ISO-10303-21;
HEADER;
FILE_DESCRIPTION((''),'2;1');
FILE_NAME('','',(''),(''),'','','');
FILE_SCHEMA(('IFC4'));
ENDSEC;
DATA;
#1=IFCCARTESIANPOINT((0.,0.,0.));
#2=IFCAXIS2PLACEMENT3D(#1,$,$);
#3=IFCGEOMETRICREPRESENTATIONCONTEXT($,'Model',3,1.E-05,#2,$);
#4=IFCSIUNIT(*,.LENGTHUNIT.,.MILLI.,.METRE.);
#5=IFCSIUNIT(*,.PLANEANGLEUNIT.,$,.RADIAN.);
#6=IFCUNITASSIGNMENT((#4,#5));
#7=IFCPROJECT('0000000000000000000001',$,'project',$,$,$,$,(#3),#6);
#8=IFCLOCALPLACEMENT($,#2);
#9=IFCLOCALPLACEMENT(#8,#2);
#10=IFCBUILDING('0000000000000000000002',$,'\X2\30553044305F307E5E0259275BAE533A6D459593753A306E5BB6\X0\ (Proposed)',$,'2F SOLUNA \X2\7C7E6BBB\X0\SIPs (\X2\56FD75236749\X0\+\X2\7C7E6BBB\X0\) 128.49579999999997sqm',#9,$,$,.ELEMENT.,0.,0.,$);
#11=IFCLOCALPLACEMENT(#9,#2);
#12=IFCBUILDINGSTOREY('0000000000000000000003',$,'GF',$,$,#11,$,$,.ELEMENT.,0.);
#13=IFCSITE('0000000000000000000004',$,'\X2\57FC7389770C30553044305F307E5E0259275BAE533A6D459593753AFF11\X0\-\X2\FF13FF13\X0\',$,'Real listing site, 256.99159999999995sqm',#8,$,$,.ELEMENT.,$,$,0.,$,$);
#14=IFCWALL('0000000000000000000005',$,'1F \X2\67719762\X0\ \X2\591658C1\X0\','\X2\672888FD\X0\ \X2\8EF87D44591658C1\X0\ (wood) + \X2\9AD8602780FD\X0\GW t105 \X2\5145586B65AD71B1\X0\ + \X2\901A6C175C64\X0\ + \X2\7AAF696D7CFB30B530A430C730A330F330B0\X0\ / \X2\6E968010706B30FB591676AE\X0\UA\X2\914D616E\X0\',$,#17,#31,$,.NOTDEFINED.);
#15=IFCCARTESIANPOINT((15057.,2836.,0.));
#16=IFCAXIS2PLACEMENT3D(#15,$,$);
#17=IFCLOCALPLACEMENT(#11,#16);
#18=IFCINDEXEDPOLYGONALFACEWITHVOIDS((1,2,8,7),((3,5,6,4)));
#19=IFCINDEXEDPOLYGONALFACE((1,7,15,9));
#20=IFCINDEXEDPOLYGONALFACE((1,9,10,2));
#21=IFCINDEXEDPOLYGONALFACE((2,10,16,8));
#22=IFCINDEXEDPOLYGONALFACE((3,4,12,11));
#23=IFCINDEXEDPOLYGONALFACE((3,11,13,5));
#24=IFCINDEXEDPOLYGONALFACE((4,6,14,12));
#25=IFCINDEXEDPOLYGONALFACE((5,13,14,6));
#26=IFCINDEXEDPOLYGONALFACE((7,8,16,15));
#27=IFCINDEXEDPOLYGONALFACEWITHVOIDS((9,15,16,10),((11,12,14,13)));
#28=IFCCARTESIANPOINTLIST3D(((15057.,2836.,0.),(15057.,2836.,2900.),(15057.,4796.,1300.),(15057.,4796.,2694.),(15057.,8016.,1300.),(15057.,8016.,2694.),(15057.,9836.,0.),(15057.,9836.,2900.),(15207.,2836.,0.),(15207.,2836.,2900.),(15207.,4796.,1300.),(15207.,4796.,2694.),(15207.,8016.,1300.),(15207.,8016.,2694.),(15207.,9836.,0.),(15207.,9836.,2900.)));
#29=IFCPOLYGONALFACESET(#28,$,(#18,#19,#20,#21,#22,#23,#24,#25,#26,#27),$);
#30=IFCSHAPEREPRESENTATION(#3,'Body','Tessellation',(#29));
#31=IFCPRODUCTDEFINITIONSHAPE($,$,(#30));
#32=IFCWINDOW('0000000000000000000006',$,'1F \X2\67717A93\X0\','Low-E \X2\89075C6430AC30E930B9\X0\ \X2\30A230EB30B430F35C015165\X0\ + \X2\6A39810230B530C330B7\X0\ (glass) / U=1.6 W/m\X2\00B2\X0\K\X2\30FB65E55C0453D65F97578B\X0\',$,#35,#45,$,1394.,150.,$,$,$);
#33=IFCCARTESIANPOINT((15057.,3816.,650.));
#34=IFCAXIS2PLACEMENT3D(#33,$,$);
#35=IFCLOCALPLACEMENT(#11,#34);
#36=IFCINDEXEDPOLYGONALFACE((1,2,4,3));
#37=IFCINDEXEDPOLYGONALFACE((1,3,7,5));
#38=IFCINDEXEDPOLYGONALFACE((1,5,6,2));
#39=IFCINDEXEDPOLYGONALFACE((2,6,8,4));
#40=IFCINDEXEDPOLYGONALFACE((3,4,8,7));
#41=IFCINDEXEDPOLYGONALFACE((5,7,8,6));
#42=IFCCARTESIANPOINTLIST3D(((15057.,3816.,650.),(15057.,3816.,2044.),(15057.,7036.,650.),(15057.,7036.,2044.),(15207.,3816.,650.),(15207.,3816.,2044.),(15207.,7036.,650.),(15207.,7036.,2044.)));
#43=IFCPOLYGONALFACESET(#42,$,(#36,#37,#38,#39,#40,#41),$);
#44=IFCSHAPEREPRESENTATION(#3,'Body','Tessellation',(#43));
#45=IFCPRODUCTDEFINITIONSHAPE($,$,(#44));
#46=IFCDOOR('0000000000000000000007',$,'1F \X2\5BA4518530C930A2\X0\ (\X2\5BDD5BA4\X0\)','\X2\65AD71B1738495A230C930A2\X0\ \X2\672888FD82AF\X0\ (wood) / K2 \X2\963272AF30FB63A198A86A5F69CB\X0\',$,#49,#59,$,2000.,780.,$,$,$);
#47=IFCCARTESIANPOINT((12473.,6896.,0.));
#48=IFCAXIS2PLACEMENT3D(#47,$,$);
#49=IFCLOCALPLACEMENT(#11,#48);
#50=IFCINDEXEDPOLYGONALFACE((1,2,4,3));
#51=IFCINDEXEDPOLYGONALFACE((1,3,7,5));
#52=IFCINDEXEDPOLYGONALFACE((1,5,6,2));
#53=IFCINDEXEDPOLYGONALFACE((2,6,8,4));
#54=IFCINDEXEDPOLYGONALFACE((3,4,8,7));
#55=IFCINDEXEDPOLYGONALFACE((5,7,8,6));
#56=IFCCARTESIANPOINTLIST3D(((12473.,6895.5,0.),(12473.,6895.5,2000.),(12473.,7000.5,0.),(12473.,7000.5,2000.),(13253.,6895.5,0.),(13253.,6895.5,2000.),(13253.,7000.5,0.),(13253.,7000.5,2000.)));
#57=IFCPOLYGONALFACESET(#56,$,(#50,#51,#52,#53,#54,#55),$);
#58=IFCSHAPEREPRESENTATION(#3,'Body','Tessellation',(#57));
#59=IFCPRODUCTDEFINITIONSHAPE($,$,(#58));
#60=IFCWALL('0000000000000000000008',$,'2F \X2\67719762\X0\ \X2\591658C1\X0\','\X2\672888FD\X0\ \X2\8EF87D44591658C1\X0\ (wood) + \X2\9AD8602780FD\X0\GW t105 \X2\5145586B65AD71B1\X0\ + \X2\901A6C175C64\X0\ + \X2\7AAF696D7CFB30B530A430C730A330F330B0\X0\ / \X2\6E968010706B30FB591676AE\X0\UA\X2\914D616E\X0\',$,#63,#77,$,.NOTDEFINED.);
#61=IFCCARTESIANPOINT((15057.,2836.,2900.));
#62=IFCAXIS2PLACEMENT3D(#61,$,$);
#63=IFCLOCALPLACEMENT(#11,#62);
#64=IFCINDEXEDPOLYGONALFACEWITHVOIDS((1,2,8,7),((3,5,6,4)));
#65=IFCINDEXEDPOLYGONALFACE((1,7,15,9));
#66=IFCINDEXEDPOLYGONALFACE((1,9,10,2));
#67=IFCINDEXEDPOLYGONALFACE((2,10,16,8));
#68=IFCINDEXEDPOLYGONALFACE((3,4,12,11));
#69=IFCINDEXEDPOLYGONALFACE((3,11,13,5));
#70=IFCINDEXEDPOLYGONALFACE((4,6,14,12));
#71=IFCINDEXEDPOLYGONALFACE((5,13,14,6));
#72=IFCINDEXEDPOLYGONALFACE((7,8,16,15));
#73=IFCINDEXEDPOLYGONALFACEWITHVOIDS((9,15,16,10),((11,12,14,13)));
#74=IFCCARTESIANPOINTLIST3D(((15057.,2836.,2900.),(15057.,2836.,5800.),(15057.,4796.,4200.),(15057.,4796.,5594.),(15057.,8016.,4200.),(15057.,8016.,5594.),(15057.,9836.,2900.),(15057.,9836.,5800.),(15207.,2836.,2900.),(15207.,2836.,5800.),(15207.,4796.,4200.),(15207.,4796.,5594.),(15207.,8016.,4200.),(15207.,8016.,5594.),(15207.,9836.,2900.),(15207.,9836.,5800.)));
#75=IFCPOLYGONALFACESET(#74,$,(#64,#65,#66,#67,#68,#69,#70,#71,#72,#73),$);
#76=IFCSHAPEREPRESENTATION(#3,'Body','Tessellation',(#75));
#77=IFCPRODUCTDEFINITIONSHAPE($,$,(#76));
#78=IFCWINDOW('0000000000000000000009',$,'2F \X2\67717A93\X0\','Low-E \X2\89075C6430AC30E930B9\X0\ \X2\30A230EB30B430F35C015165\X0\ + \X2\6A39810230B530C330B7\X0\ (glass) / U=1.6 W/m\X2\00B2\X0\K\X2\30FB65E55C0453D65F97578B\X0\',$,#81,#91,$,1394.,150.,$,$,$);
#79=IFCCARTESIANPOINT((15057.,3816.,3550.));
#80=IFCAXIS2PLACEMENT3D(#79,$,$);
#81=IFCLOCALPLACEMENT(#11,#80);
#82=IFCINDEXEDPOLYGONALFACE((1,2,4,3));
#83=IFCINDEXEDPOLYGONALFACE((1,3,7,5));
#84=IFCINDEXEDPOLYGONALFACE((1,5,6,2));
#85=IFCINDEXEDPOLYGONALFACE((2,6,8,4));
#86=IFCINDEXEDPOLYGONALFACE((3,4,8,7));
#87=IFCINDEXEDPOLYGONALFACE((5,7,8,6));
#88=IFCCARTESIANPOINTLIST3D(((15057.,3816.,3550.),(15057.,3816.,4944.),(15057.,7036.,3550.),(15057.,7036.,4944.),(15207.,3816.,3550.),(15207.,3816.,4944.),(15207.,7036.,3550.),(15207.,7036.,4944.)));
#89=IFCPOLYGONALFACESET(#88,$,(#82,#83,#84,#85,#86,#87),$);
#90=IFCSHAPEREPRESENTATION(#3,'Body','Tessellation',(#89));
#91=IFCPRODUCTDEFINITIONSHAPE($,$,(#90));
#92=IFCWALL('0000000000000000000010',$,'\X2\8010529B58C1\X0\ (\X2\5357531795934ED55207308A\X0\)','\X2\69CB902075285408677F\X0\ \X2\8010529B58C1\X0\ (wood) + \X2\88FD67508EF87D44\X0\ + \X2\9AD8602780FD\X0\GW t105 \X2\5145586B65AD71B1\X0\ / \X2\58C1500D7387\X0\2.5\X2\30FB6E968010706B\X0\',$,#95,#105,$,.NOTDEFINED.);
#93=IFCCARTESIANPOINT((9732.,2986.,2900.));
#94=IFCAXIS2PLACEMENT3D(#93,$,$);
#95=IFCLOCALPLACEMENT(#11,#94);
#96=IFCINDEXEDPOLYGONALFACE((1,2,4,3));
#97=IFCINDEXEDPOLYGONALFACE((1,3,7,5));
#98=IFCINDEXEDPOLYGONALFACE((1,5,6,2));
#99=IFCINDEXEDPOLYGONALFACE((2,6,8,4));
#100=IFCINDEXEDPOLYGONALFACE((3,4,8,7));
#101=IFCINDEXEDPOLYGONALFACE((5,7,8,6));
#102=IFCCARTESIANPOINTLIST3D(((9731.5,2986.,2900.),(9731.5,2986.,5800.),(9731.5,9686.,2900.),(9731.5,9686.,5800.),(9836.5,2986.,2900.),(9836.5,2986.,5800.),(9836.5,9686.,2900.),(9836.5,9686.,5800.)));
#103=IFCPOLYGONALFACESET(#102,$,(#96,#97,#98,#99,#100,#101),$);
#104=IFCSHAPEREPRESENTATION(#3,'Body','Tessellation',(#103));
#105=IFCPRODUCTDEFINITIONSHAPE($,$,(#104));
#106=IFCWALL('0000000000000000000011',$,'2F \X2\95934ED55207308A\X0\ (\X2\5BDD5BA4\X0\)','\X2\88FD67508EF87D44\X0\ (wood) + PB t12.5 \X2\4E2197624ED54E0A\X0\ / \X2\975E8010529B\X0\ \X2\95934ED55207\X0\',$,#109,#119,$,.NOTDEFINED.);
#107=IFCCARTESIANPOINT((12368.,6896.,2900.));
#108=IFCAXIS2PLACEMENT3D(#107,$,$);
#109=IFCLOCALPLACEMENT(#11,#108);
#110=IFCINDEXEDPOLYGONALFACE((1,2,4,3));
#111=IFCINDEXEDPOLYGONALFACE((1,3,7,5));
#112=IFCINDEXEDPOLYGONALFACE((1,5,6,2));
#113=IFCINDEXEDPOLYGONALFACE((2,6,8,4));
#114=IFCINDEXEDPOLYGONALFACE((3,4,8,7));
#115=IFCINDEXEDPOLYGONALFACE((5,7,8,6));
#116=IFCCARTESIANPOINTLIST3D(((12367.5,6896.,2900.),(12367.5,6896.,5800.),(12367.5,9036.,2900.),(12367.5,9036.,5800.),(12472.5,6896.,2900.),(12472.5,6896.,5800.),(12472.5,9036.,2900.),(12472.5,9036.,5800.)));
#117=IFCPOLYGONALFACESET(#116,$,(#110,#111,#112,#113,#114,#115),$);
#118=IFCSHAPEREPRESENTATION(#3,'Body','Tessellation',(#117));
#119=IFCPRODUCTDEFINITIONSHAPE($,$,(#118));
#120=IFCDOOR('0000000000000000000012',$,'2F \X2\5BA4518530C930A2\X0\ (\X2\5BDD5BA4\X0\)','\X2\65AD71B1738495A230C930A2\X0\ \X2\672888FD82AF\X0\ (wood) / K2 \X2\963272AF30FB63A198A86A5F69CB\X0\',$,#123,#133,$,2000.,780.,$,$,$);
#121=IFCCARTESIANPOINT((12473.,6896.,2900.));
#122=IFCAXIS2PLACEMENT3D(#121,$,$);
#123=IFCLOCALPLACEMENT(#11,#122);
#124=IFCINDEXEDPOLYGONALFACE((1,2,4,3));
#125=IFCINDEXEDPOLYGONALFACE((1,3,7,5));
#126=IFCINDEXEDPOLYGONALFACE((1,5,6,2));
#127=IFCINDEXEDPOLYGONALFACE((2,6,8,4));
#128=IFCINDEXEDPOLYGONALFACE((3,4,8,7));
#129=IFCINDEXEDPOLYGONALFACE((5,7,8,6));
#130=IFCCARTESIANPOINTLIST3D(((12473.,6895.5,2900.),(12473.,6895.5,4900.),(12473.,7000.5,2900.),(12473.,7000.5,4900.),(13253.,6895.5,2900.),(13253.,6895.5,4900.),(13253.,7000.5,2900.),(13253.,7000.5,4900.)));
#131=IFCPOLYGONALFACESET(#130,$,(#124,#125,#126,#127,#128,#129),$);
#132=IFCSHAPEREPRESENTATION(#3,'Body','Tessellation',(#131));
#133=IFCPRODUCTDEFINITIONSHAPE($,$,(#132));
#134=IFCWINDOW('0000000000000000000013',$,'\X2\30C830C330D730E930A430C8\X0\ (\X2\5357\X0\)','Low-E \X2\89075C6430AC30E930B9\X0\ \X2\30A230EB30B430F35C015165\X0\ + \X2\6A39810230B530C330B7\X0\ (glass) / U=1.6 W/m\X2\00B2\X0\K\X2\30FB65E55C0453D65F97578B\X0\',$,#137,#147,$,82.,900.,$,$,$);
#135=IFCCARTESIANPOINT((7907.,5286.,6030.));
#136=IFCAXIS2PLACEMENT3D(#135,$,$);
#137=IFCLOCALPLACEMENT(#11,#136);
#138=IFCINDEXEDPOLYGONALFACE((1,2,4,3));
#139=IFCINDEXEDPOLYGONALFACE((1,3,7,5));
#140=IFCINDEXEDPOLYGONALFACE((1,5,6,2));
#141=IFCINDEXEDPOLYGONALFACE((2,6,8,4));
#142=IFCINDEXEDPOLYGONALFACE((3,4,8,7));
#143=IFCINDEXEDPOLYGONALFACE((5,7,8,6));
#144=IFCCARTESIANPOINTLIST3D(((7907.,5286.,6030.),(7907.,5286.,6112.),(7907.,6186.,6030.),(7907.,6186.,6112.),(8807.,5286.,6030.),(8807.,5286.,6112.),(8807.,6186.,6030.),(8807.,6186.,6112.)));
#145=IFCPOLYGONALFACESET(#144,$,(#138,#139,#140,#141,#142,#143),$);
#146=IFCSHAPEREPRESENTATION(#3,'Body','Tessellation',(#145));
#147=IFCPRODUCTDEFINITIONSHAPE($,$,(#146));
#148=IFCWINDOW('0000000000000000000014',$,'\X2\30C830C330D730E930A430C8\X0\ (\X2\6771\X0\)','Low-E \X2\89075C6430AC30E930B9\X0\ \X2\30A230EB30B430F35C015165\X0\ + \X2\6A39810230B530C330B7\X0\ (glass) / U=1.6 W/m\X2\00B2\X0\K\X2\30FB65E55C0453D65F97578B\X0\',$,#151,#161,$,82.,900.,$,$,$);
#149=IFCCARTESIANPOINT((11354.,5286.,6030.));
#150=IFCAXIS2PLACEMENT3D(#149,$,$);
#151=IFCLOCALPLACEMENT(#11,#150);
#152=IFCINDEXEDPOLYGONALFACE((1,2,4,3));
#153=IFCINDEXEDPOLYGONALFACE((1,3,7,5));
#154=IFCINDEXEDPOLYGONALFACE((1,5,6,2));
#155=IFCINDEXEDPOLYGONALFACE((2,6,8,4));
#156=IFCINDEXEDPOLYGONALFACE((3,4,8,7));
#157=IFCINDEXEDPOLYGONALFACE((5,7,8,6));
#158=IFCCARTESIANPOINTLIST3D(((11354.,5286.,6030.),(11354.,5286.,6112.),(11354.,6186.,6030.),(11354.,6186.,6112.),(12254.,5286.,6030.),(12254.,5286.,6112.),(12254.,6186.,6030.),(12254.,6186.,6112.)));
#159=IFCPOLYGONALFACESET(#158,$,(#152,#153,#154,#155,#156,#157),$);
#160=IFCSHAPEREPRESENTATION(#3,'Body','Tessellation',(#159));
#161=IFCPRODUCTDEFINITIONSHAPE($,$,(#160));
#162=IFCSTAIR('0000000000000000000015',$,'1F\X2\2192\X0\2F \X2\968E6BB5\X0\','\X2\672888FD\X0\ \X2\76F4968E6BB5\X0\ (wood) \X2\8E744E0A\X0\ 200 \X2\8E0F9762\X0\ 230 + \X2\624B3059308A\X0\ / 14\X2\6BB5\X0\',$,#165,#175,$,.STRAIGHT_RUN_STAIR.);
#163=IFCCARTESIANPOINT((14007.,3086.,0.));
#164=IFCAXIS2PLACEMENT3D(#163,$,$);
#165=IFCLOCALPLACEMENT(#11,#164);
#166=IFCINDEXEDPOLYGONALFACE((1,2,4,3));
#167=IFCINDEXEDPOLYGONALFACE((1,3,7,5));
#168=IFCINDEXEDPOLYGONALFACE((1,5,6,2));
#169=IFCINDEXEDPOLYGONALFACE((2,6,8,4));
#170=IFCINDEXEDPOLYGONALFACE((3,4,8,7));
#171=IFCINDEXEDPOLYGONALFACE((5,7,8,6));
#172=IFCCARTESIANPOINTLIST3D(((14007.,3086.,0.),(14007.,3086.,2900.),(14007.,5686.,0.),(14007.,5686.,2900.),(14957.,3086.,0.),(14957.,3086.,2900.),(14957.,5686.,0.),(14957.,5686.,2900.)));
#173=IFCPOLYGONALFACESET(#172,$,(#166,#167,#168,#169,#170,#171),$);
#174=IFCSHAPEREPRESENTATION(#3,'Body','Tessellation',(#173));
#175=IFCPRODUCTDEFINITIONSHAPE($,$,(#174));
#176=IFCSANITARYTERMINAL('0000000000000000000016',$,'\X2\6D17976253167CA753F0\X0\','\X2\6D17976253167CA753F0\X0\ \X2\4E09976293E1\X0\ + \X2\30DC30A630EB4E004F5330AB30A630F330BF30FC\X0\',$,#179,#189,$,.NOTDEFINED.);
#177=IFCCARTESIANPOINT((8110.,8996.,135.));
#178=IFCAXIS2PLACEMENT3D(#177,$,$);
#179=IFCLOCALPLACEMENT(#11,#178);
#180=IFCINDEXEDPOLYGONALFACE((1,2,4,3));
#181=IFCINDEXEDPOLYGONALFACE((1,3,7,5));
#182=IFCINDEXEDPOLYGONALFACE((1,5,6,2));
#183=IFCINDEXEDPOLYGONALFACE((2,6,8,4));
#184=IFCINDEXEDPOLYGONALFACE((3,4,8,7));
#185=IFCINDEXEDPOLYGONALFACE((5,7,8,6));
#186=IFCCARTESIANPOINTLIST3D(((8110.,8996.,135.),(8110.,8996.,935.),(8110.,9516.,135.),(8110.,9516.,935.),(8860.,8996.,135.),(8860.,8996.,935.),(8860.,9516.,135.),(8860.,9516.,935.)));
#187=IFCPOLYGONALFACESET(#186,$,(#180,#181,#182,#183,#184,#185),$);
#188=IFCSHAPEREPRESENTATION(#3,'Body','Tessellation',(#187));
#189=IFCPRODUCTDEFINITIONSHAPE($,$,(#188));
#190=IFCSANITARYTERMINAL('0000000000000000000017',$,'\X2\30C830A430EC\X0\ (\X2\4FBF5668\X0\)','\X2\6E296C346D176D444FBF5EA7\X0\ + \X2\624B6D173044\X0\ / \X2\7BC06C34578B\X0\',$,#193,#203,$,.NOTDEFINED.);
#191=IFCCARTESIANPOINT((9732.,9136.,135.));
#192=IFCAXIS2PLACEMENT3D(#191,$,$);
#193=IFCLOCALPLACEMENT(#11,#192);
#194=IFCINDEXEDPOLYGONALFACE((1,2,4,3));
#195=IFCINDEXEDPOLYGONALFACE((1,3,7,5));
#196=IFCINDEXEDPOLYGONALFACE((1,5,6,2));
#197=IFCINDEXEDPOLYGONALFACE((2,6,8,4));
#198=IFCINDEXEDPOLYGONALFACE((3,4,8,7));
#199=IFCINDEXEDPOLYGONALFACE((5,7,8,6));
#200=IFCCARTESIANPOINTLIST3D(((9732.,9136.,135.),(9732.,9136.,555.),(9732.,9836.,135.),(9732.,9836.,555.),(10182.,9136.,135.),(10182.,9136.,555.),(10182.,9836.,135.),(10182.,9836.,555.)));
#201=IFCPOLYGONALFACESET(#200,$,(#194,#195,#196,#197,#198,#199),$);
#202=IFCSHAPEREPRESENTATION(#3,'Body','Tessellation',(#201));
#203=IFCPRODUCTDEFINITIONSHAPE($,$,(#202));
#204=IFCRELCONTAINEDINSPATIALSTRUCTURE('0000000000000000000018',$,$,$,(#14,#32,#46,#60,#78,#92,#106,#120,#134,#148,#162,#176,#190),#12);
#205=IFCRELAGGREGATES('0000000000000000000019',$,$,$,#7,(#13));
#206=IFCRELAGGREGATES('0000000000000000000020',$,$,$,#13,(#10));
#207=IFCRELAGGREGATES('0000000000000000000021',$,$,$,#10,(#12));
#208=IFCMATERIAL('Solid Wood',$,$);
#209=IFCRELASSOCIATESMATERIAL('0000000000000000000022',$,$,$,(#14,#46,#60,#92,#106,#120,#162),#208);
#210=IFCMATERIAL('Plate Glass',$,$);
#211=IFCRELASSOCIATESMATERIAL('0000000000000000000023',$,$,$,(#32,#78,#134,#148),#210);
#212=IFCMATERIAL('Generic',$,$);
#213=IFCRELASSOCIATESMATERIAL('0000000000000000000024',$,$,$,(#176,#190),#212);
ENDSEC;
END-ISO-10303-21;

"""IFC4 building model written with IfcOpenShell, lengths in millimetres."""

from ifc_helpers import new_model, si_unit, frame, frame_2d, origin, place, context, project, spatial, rectangle, extrude, material, element, fill, save


model = new_model("IFC4")

# Units and contexts
model_context = context("Model", 3, precision=1e-05, world=origin())
ifc_project = project(units=[si_unit("LENGTHUNIT", "METRE", prefix="MILLI"), si_unit("PLANEANGLEUNIT", "RADIAN")], contexts=[model_context])

# Site, building, storey
site_placement = place(None, origin())
site = spatial("IfcSite", under=ifc_project, at=site_placement, Name="埼玉県さいたま市大宮区浅間町１-３３", ObjectType="Real listing site, 256.99159999999995sqm", CompositionType="ELEMENT", RefElevation=0.0)
building_placement = place(site_placement, origin())
building = spatial("IfcBuilding", under=site, at=building_placement, Name="さいたま市大宮区浅間町の家 (Proposed)", ObjectType="2F SOLUNA 籾殻SIPs (国産杉+籾殻) 128.49579999999997sqm", CompositionType="ELEMENT", ElevationOfRefHeight=0.0, ElevationOfTerrain=0.0)
storey_placement = place(building_placement, origin())
storey = spatial("IfcBuildingStorey", under=building, at=storey_placement, Name="GF", CompositionType="ELEMENT", Elevation=0.0)

# Wall, opening, window
ifc_material_1 = material(Name="Solid Wood")
wall_1_placement = place(storey_placement, frame((15057.0, 2836.0, 0.0)))
wall_1 = element("IfcWall", 1, at=wall_1_placement, inside=storey, material=ifc_material_1, Name="1F 東面 外壁", Description="木製 軸組外壁 (wood) + 高性能GW t105 充填断熱 + 通気層 + 窯業系サイディング / 準耐火・外皮UA配慮", PredefinedType="NOTDEFINED", context=model_context, shape_type="SweptSolid", body=[
    extrude(rectangle(XDim=150.0, YDim=7000.0, at=frame_2d((75.0, 3500.0))), frame((15057.0, 2836.0, 0.0)), (0.0, 0.0, 1.0), 2900.0),
])
opening_1_placement = place(storey_placement, frame((15057.0, 3816.0, 650.0)))
opening_1 = element("IfcOpeningElement", 2, at=opening_1_placement, cuts=wall_1, PredefinedType="NOTDEFINED", context=model_context, shape_type="SweptSolid", body=[
    extrude(rectangle(XDim=150.0, YDim=3220.0, at=frame_2d((75.0, 1610.0))), frame((15057.0, 3816.0, 650.0)), (0.0, 0.0, 1.0), 1394.0),
])
ifc_material_2 = material(Name="Plate Glass")
window_1_placement = place(storey_placement, frame((15057.0, 3816.0, 650.0)))
window_1 = element("IfcWindow", 3, at=window_1_placement, inside=storey, material=ifc_material_2, Name="1F 東窓", Description="Low-E 複層ガラス アルゴン封入 + 樹脂サッシ (glass) / U=1.6 W/m²K・日射取得型", OverallHeight=1394.0, OverallWidth=150.0, context=model_context, shape_type="SweptSolid", body=[
    extrude(rectangle(XDim=150.0, YDim=3220.0, at=frame_2d((75.0, 1610.0))), frame((15057.0, 3816.0, 650.0)), (0.0, 0.0, 1.0), 1394.0),
])
fill(opening_1, window_1)

# Door
door_1_placement = place(storey_placement, frame((12473.0, 6896.0, 0.0)))
element("IfcDoor", 4, at=door_1_placement, inside=storey, material=ifc_material_1, Name="1F 室内ドア (寝室)", Description="断熱玄関ドア 木製芯 (wood) / K2 防犯・採風機構", OverallHeight=2000.0, OverallWidth=780.0, context=model_context, shape_type="SweptSolid", body=[
    extrude(rectangle(XDim=780.0, YDim=105.0, at=frame_2d((390.0, 52.0))), frame((12473.0, 6896.0, 0.0)), (0.0, 0.0, 1.0), 2000.0),
])

# Wall, opening, window
wall_2_placement = place(storey_placement, frame((15057.0, 2836.0, 2900.0)))
wall_2 = element("IfcWall", 5, at=wall_2_placement, inside=storey, material=ifc_material_1, Name="2F 東面 外壁", Description="木製 軸組外壁 (wood) + 高性能GW t105 充填断熱 + 通気層 + 窯業系サイディング / 準耐火・外皮UA配慮", PredefinedType="NOTDEFINED", context=model_context, shape_type="SweptSolid", body=[
    extrude(rectangle(XDim=150.0, YDim=7000.0, at=frame_2d((75.0, 3500.0))), frame((15057.0, 2836.0, 2900.0)), (0.0, 0.0, 1.0), 2900.0),
])
opening_2_placement = place(storey_placement, frame((15057.0, 3816.0, 3550.0)))
opening_2 = element("IfcOpeningElement", 6, at=opening_2_placement, cuts=wall_2, PredefinedType="NOTDEFINED", context=model_context, shape_type="SweptSolid", body=[
    extrude(rectangle(XDim=150.0, YDim=3220.0, at=frame_2d((75.0, 1610.0))), frame((15057.0, 3816.0, 3550.0)), (0.0, 0.0, 1.0), 1394.0),
])
window_2_placement = place(storey_placement, frame((15057.0, 3816.0, 3550.0)))
window_2 = element("IfcWindow", 7, at=window_2_placement, inside=storey, material=ifc_material_2, Name="2F 東窓", Description="Low-E 複層ガラス アルゴン封入 + 樹脂サッシ (glass) / U=1.6 W/m²K・日射取得型", OverallHeight=1394.0, OverallWidth=150.0, context=model_context, shape_type="SweptSolid", body=[
    extrude(rectangle(XDim=150.0, YDim=3220.0, at=frame_2d((75.0, 1610.0))), frame((15057.0, 3816.0, 3550.0)), (0.0, 0.0, 1.0), 1394.0),
])
fill(opening_2, window_2)

# Walls
wall_3_placement = place(storey_placement, frame((9732.0, 2986.0, 2900.0)))
element("IfcWall", 8, at=wall_3_placement, inside=storey, material=ifc_material_1, Name="耐力壁 (南北間仕切り)", Description="構造用合板 耐力壁 (wood) + 製材軸組 + 高性能GW t105 充填断熱 / 壁倍率2.5・準耐火", PredefinedType="NOTDEFINED", context=model_context, shape_type="SweptSolid", body=[
    extrude(rectangle(XDim=105.0, YDim=6700.0, at=frame_2d((52.0, 3350.0))), frame((9732.0, 2986.0, 2900.0)), (0.0, 0.0, 1.0), 2900.0),
])
wall_4_placement = place(storey_placement, frame((12368.0, 6896.0, 2900.0)))
element("IfcWall", 9, at=wall_4_placement, inside=storey, material=ifc_material_1, Name="2F 間仕切り (寝室)", Description="製材軸組 (wood) + PB t12.5 両面仕上 / 非耐力 間仕切", PredefinedType="NOTDEFINED", context=model_context, shape_type="SweptSolid", body=[
    extrude(rectangle(XDim=105.0, YDim=2140.0, at=frame_2d((52.0, 1070.0))), frame((12368.0, 6896.0, 2900.0)), (0.0, 0.0, 1.0), 2900.0),
])

# Door
door_2_placement = place(storey_placement, frame((12473.0, 6896.0, 2900.0)))
element("IfcDoor", 10, at=door_2_placement, inside=storey, material=ifc_material_1, Name="2F 室内ドア (寝室)", Description="断熱玄関ドア 木製芯 (wood) / K2 防犯・採風機構", OverallHeight=2000.0, OverallWidth=780.0, context=model_context, shape_type="SweptSolid", body=[
    extrude(rectangle(XDim=780.0, YDim=105.0, at=frame_2d((390.0, 52.0))), frame((12473.0, 6896.0, 2900.0)), (0.0, 0.0, 1.0), 2000.0),
])

# Windows
window_3_placement = place(storey_placement, frame((7907.0, 5286.0, 6030.0)))
element("IfcWindow", 11, at=window_3_placement, inside=storey, material=ifc_material_2, Name="トップライト (南)", Description="Low-E 複層ガラス アルゴン封入 + 樹脂サッシ (glass) / U=1.6 W/m²K・日射取得型", OverallHeight=82.0, OverallWidth=900.0, context=model_context, shape_type="SweptSolid", body=[
    extrude(rectangle(XDim=900.0, YDim=900.0, at=frame_2d((450.0, 450.0))), frame((7907.0, 5286.0, 6030.0)), (0.0, 0.0, 1.0), 82.0),
])
window_4_placement = place(storey_placement, frame((11354.0, 5286.0, 6030.0)))
element("IfcWindow", 12, at=window_4_placement, inside=storey, material=ifc_material_2, Name="トップライト (東)", Description="Low-E 複層ガラス アルゴン封入 + 樹脂サッシ (glass) / U=1.6 W/m²K・日射取得型", OverallHeight=82.0, OverallWidth=900.0, context=model_context, shape_type="SweptSolid", body=[
    extrude(rectangle(XDim=900.0, YDim=900.0, at=frame_2d((450.0, 450.0))), frame((11354.0, 5286.0, 6030.0)), (0.0, 0.0, 1.0), 82.0),
])

# Stair
stair_placement = place(storey_placement, frame((14007.0, 3086.0, 0.0)))
element("IfcStair", 13, at=stair_placement, inside=storey, material=ifc_material_1, Name="1F→2F 階段", Description="木製 直階段 (wood) 蹴上 200 踏面 230 + 手すり / 14段", PredefinedType="STRAIGHT_RUN_STAIR", context=model_context, shape_type="SweptSolid", body=[
    extrude(rectangle(XDim=950.0, YDim=2600.0, at=frame_2d((475.0, 1300.0))), frame((14007.0, 3086.0, 0.0)), (0.0, 0.0, 1.0), 2900.0),
])

# Sanitary terminals
ifc_material_3 = material(Name="Generic")
sanitary_terminal_1_placement = place(storey_placement, frame((8110.0, 8996.0, 135.0)))
element("IfcSanitaryTerminal", 14, at=sanitary_terminal_1_placement, inside=storey, material=ifc_material_3, Name="洗面化粧台", Description="洗面化粧台 三面鏡 + ボウル一体カウンター", PredefinedType="NOTDEFINED", context=model_context, shape_type="SweptSolid", body=[
    extrude(rectangle(XDim=750.0, YDim=520.0, at=frame_2d((375.0, 260.0))), frame((8110.0, 8996.0, 135.0)), (0.0, 0.0, 1.0), 800.0),
])
sanitary_terminal_2_placement = place(storey_placement, frame((9732.0, 9136.0, 135.0)))
element("IfcSanitaryTerminal", 15, at=sanitary_terminal_2_placement, inside=storey, material=ifc_material_3, Name="トイレ (便器)", Description="温水洗浄便座 + 手洗い / 節水型", PredefinedType="NOTDEFINED", context=model_context, shape_type="SweptSolid", body=[
    extrude(rectangle(XDim=450.0, YDim=700.0, at=frame_2d((225.0, 350.0))), frame((9732.0, 9136.0, 135.0)), (0.0, 0.0, 1.0), 420.0),
])

save(model, "model.ifc")
